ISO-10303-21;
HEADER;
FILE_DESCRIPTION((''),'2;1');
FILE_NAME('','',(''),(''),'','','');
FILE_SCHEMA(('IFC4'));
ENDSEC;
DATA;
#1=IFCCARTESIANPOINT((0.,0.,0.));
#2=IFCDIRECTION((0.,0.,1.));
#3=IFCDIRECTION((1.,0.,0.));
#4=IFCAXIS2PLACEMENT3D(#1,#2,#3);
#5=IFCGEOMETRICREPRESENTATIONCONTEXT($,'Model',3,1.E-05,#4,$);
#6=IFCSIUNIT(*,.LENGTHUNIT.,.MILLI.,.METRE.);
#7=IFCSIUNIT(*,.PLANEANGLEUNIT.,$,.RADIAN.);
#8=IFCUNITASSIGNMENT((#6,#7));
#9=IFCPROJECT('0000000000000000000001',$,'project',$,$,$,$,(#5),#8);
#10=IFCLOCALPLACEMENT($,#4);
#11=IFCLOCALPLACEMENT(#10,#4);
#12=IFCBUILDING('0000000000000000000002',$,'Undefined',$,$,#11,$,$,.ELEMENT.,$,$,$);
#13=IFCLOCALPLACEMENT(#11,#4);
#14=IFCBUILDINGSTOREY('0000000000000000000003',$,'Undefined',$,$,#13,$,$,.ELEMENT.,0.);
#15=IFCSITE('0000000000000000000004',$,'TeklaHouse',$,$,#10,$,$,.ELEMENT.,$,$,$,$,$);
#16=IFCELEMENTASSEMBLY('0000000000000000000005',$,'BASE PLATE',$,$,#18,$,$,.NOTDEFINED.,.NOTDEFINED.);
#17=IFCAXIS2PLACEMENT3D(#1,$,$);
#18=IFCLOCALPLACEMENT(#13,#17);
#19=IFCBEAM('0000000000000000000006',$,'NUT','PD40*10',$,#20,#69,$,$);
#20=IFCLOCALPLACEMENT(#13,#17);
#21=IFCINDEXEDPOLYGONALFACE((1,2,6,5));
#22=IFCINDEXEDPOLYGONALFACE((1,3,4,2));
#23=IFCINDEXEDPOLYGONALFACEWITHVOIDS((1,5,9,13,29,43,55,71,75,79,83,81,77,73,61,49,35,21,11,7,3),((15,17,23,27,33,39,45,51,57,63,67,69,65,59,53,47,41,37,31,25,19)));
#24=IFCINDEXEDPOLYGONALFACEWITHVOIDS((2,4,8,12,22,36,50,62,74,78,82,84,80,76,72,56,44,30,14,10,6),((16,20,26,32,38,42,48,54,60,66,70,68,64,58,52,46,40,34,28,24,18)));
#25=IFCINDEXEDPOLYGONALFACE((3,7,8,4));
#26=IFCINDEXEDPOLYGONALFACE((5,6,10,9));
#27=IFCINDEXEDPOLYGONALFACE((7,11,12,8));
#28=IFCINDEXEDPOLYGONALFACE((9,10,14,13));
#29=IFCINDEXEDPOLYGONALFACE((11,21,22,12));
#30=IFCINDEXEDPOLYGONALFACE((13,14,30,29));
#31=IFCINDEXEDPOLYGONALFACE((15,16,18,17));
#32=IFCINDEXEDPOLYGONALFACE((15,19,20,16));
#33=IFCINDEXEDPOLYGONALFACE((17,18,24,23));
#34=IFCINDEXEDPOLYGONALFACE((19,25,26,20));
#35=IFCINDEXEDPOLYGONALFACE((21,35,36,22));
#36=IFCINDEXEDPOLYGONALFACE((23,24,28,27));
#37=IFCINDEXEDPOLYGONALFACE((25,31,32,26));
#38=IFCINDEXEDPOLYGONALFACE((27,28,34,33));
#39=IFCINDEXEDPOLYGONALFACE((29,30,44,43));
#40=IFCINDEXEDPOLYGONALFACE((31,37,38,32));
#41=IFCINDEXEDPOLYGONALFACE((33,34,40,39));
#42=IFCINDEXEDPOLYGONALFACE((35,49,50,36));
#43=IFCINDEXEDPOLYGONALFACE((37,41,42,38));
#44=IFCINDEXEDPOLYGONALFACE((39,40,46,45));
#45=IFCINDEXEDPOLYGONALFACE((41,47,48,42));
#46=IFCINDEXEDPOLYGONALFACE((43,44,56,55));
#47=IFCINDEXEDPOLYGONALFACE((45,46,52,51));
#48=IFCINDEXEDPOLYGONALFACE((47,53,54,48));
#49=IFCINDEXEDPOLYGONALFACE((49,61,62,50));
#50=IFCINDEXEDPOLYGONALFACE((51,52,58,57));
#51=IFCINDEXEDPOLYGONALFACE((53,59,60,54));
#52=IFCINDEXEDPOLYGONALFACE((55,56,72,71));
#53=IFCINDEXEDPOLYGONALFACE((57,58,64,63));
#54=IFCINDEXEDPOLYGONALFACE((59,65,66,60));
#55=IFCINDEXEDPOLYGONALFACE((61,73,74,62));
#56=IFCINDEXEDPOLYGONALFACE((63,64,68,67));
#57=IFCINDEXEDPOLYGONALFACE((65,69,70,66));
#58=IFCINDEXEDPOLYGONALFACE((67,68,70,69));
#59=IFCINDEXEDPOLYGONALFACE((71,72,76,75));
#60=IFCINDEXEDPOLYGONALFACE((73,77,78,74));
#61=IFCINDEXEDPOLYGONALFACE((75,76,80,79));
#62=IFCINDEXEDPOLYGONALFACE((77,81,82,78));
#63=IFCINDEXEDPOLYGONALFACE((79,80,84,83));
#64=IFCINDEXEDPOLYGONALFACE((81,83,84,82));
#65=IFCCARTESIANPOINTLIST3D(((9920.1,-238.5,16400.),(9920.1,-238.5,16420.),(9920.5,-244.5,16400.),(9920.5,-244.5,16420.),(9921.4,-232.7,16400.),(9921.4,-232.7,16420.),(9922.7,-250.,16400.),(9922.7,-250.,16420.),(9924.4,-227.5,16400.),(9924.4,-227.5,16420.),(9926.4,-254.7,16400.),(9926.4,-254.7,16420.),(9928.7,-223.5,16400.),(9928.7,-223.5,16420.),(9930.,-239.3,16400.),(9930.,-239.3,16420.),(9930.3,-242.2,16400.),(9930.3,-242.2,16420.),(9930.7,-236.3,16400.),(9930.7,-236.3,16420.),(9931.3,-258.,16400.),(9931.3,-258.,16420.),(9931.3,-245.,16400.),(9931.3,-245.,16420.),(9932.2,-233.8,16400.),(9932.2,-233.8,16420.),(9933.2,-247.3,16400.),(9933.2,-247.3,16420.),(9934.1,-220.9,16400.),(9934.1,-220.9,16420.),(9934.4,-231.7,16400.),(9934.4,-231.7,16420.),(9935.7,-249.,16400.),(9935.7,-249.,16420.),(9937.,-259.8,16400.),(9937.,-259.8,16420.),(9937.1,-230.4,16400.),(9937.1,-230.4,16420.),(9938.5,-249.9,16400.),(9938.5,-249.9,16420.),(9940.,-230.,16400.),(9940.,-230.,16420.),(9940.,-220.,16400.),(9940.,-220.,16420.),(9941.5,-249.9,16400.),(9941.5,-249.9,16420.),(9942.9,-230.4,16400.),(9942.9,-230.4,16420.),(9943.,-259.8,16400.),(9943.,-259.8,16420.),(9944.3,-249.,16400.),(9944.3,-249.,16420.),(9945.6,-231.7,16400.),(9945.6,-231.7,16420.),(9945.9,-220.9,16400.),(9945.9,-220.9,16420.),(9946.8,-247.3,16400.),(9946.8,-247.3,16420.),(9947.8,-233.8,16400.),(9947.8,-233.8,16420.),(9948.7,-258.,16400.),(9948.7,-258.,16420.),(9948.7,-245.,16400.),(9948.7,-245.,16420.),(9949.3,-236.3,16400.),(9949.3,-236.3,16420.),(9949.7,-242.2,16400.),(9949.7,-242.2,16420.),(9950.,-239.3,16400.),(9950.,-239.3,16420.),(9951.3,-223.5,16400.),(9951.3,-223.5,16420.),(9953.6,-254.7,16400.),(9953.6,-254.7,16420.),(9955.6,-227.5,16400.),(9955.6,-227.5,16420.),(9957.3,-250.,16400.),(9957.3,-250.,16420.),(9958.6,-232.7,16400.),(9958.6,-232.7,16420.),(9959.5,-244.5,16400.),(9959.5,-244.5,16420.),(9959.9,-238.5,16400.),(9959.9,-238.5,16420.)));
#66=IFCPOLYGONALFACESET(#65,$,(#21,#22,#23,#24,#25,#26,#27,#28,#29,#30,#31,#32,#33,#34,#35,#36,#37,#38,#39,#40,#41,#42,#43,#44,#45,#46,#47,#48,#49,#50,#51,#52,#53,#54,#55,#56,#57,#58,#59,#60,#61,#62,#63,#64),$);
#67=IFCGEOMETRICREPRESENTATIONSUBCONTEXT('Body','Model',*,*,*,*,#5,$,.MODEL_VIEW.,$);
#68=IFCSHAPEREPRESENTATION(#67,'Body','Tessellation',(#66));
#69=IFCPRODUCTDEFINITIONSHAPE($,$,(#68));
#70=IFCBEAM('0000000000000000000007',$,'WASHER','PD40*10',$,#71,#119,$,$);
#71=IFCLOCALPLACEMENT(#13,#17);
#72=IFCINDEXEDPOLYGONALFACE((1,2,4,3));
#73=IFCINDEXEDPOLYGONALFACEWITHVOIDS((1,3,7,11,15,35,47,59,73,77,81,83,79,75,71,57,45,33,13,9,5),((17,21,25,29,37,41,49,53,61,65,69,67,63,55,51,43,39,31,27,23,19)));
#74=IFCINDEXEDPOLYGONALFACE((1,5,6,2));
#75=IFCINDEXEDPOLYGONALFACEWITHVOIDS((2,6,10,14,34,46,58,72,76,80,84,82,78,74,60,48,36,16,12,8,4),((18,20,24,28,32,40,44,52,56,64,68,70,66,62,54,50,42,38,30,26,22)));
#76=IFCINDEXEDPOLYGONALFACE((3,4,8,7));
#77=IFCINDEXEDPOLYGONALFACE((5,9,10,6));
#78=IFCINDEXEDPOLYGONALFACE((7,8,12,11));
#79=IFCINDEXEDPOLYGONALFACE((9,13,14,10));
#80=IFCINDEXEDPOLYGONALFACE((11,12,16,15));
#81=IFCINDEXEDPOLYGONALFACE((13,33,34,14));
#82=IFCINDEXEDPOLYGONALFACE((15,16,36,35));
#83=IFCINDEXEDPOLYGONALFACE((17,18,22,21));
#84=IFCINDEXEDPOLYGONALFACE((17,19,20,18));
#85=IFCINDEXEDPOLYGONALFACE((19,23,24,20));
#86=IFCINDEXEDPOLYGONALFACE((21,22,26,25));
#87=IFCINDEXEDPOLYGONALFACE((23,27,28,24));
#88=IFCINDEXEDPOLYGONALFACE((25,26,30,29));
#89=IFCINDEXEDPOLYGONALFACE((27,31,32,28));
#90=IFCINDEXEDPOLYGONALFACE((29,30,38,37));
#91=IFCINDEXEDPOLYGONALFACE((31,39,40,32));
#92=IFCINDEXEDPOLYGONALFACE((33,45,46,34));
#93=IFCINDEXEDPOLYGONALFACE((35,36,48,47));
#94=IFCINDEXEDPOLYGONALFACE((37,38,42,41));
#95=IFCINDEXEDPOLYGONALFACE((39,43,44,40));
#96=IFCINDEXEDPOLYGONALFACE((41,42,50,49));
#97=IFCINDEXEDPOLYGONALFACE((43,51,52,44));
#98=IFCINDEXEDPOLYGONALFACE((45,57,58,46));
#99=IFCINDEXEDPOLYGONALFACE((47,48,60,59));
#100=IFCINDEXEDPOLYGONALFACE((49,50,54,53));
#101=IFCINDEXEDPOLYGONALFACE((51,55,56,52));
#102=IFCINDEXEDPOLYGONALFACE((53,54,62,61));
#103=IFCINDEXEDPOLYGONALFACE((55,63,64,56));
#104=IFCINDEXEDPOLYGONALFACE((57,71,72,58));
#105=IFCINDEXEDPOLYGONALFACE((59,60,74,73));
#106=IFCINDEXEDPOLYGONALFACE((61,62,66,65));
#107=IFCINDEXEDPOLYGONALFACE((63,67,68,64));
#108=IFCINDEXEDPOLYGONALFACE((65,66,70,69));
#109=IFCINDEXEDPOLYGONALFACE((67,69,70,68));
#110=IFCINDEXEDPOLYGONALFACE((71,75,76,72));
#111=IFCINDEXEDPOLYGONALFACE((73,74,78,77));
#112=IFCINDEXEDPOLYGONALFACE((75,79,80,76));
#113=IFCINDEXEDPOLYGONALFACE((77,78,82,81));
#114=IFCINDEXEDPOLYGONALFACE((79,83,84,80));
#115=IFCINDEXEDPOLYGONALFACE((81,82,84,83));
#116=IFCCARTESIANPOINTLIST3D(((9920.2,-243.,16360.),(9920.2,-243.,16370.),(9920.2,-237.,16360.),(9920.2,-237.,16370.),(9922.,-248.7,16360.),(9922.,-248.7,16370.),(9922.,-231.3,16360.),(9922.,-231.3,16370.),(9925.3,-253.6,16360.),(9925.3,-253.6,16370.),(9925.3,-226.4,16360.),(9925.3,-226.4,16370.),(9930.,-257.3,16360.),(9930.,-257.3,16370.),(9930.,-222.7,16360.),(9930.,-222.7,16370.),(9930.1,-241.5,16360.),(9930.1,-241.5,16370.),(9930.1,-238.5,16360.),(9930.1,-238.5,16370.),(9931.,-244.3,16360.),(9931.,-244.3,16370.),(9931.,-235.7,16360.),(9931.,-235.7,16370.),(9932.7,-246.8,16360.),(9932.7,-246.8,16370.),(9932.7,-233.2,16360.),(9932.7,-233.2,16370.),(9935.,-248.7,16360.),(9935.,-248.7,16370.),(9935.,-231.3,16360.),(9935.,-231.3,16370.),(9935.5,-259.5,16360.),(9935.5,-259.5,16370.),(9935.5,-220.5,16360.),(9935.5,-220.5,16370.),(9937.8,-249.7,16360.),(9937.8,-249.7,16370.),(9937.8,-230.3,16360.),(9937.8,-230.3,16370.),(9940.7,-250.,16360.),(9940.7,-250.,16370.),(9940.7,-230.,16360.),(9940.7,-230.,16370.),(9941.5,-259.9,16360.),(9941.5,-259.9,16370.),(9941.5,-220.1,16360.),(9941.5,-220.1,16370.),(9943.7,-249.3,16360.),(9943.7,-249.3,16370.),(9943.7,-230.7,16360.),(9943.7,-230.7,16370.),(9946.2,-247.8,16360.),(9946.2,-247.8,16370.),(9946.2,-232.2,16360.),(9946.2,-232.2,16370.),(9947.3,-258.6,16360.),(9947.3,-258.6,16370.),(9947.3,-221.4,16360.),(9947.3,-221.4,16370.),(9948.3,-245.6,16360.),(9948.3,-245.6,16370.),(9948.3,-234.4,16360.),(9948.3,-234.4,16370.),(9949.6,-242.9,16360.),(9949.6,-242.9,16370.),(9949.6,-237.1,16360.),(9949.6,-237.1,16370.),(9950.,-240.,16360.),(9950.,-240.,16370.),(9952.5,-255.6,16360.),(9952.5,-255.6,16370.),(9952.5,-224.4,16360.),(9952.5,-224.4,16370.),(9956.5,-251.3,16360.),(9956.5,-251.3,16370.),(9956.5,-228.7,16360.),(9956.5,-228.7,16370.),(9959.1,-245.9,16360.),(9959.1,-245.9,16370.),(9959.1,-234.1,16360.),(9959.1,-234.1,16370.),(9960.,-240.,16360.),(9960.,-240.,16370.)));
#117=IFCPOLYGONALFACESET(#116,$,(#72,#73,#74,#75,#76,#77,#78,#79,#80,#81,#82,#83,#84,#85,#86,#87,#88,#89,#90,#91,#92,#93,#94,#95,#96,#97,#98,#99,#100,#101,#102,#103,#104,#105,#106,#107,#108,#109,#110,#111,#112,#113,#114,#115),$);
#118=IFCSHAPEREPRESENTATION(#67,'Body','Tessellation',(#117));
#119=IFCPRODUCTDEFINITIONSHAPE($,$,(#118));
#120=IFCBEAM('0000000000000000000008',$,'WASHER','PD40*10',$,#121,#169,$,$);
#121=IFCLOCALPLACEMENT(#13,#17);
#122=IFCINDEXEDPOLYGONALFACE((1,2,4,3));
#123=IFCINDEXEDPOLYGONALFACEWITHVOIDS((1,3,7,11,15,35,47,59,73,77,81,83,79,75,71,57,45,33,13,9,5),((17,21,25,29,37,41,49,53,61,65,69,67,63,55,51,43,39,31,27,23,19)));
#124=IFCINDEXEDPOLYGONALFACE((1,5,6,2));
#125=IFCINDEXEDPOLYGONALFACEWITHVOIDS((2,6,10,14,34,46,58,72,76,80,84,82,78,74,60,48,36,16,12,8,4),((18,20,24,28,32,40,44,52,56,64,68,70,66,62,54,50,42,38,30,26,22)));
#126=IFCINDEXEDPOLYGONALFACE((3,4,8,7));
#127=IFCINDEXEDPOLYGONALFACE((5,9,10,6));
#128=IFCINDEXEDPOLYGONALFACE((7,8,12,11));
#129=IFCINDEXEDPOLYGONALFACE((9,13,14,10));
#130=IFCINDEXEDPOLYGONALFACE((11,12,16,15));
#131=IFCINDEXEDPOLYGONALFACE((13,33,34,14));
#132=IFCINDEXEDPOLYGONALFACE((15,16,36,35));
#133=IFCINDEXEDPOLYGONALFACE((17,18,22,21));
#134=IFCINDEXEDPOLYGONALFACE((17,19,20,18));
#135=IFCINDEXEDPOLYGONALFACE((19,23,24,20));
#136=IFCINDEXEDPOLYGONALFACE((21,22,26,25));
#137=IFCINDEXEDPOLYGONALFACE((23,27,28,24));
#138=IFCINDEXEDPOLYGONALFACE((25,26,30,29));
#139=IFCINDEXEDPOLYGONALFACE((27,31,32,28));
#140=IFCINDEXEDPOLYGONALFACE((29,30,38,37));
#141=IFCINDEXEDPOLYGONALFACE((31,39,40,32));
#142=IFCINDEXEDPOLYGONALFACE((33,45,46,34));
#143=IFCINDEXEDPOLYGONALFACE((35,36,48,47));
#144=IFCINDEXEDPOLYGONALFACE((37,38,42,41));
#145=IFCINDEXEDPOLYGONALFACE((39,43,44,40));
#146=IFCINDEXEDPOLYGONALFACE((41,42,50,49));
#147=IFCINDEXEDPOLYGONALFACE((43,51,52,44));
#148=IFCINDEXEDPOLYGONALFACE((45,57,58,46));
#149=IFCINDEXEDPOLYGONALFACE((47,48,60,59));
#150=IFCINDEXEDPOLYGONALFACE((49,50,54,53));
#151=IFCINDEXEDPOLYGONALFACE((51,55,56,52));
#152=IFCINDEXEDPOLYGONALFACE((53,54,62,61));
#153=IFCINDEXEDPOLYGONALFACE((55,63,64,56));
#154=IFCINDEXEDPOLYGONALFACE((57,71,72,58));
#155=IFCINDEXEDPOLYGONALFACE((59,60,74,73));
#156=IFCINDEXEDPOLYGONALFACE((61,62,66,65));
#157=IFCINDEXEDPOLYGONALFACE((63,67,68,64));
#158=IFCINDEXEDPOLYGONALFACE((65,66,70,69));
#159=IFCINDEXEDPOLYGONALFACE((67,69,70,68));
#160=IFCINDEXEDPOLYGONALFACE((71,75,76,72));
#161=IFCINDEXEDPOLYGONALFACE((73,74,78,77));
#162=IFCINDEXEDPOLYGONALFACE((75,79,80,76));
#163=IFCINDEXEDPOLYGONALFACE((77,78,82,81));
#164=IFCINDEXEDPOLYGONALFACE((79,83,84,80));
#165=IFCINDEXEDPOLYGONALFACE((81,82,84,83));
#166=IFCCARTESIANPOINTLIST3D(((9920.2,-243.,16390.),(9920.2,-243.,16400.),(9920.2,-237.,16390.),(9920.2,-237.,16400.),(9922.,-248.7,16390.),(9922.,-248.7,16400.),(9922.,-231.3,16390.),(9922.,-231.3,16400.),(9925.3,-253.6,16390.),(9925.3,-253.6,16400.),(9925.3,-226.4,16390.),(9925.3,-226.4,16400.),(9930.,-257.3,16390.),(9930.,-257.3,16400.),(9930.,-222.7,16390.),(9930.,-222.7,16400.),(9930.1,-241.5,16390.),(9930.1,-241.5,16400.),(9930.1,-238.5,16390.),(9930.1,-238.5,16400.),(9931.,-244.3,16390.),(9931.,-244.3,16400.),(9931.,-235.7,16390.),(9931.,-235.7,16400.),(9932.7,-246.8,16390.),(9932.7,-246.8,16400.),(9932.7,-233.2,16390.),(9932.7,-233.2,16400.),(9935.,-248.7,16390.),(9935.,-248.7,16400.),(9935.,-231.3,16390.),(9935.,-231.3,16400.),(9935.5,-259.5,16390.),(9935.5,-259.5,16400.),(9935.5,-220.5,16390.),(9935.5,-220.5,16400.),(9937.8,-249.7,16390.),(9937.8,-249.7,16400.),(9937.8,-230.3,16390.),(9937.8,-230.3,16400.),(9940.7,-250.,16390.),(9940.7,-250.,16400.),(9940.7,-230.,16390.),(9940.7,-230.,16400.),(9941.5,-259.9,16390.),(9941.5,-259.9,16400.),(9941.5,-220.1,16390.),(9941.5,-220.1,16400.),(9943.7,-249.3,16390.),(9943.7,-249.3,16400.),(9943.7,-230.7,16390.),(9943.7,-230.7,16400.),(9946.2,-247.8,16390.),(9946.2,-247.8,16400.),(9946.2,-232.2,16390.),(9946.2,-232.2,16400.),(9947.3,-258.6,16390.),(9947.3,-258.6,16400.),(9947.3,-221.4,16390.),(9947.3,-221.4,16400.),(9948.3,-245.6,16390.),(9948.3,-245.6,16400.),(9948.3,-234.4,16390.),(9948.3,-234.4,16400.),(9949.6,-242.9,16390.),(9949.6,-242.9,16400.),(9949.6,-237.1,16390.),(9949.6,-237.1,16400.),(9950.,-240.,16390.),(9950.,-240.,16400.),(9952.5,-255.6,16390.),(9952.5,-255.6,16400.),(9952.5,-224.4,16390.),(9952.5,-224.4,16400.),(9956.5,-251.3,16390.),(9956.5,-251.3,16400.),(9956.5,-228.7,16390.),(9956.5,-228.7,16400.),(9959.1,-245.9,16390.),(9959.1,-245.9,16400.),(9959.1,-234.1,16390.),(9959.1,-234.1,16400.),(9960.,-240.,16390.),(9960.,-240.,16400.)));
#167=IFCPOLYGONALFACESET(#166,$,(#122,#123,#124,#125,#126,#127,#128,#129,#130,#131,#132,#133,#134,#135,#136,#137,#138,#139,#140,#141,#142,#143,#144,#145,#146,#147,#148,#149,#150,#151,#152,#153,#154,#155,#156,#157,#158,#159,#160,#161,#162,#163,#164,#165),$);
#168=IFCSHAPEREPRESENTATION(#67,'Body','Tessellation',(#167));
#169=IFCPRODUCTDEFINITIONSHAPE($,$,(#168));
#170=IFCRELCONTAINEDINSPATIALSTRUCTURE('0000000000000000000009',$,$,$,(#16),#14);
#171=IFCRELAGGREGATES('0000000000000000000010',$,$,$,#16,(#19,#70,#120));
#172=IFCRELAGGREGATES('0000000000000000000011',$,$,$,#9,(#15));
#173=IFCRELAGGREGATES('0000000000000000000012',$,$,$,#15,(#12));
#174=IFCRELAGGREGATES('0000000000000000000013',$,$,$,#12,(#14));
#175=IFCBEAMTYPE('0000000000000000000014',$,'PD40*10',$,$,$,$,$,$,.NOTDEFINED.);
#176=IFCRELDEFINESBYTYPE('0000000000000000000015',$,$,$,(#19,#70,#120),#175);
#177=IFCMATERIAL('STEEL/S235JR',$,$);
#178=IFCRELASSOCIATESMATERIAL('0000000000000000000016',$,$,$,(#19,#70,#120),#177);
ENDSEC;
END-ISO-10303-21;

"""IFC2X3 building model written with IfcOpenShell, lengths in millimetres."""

from ifc_helpers import new_model, si_unit, frame, origin_with_axes, origin_2d_with_axis, place, context, subcontext, project, spatial, hollow_circle, extrude, material, type_object, element, aggregate, save


model = new_model("IFC2X3")

# Units and contexts
model_context = context("Model", 3, precision=1e-05, world=origin_with_axes())
body_context = subcontext(model_context, "Body", "Model", "MODEL_VIEW")
ifc_project = project(units=[si_unit("LENGTHUNIT", "METRE", prefix="MILLI"), si_unit("PLANEANGLEUNIT", "RADIAN")], contexts=[model_context])

# Site, building, storey
site_placement = place(None, origin_with_axes())
site = spatial("IfcSite", under=ifc_project, at=site_placement, Name="TeklaHouse", CompositionType="ELEMENT")
building_placement = place(site_placement, origin_with_axes())
building = spatial("IfcBuilding", under=site, at=building_placement, Name="Undefined", CompositionType="ELEMENT")
storey_placement = place(building_placement, origin_with_axes())
storey = spatial("IfcBuildingStorey", under=building, at=storey_placement, Name="Undefined", CompositionType="ELEMENT", Elevation=0.0)

# Element assembly, beams
assembly_1_placement = place(storey_placement, origin_with_axes())
assembly_1 = element("IfcElementAssembly", 1, at=assembly_1_placement, inside=storey, Name="BASE PLATE", AssemblyPlace="NOTDEFINED", PredefinedType="NOTDEFINED")
ifc_material_1 = material(Name="STEEL/S235JR")
beam_type_1 = type_object("IfcBeamType", Name="PD40*10", PredefinedType="NOTDEFINED")
beam_1_placement = place(assembly_1_placement, frame((9940.0, -240.0, 16420.0), z_axis=(-1.0, 0.0, 0.0), x_axis=(0.0, 0.0, -1.0)))
beam_1 = element("IfcBeam", 2, at=beam_1_placement, type_object=beam_type_1, material=ifc_material_1, Name="NUT", Description="PD40*10", context=body_context, shape_type="SweptSolid", body=[
    extrude(hollow_circle(Radius=20.0, WallThickness=10.0, at=origin_2d_with_axis()), frame((20.0, 0.0, 0.0), z_axis=(-1.0, 0.0, 0.0), x_axis=(0.0, -1.0, 0.0)), (0.0, 0.0, 1.0), 20.0),
])
beam_2_placement = place(assembly_1_placement, frame((9940.0, -240.0, 16370.0), z_axis=(0.0, 1.0, 0.0), x_axis=(0.0, 0.0, -1.0)))
beam_2 = element("IfcBeam", 3, at=beam_2_placement, type_object=beam_type_1, material=ifc_material_1, Name="WASHER", Description="PD40*10", context=body_context, shape_type="SweptSolid", body=[
    extrude(hollow_circle(Radius=20.0, WallThickness=10.0, at=origin_2d_with_axis()), frame((10.0, 0.0, 0.0), z_axis=(-1.0, 0.0, 0.0), x_axis=(0.0, -1.0, 0.0)), (0.0, 0.0, 1.0), 10.0),
])
beam_3_placement = place(assembly_1_placement, frame((9940.0, -240.0, 16400.0), z_axis=(0.0, 1.0, 0.0), x_axis=(0.0, 0.0, -1.0)))
beam_3 = element("IfcBeam", 4, at=beam_3_placement, type_object=beam_type_1, material=ifc_material_1, Name="WASHER", Description="PD40*10", context=body_context, shape_type="SweptSolid", body=[
    extrude(hollow_circle(Radius=20.0, WallThickness=10.0, at=origin_2d_with_axis()), frame((10.0, 0.0, 0.0), z_axis=(-1.0, 0.0, 0.0), x_axis=(0.0, -1.0, 0.0)), (0.0, 0.0, 1.0), 10.0),
])

aggregate(assembly_1, [beam_1, beam_2, beam_3])

save(model, "model.ifc")
